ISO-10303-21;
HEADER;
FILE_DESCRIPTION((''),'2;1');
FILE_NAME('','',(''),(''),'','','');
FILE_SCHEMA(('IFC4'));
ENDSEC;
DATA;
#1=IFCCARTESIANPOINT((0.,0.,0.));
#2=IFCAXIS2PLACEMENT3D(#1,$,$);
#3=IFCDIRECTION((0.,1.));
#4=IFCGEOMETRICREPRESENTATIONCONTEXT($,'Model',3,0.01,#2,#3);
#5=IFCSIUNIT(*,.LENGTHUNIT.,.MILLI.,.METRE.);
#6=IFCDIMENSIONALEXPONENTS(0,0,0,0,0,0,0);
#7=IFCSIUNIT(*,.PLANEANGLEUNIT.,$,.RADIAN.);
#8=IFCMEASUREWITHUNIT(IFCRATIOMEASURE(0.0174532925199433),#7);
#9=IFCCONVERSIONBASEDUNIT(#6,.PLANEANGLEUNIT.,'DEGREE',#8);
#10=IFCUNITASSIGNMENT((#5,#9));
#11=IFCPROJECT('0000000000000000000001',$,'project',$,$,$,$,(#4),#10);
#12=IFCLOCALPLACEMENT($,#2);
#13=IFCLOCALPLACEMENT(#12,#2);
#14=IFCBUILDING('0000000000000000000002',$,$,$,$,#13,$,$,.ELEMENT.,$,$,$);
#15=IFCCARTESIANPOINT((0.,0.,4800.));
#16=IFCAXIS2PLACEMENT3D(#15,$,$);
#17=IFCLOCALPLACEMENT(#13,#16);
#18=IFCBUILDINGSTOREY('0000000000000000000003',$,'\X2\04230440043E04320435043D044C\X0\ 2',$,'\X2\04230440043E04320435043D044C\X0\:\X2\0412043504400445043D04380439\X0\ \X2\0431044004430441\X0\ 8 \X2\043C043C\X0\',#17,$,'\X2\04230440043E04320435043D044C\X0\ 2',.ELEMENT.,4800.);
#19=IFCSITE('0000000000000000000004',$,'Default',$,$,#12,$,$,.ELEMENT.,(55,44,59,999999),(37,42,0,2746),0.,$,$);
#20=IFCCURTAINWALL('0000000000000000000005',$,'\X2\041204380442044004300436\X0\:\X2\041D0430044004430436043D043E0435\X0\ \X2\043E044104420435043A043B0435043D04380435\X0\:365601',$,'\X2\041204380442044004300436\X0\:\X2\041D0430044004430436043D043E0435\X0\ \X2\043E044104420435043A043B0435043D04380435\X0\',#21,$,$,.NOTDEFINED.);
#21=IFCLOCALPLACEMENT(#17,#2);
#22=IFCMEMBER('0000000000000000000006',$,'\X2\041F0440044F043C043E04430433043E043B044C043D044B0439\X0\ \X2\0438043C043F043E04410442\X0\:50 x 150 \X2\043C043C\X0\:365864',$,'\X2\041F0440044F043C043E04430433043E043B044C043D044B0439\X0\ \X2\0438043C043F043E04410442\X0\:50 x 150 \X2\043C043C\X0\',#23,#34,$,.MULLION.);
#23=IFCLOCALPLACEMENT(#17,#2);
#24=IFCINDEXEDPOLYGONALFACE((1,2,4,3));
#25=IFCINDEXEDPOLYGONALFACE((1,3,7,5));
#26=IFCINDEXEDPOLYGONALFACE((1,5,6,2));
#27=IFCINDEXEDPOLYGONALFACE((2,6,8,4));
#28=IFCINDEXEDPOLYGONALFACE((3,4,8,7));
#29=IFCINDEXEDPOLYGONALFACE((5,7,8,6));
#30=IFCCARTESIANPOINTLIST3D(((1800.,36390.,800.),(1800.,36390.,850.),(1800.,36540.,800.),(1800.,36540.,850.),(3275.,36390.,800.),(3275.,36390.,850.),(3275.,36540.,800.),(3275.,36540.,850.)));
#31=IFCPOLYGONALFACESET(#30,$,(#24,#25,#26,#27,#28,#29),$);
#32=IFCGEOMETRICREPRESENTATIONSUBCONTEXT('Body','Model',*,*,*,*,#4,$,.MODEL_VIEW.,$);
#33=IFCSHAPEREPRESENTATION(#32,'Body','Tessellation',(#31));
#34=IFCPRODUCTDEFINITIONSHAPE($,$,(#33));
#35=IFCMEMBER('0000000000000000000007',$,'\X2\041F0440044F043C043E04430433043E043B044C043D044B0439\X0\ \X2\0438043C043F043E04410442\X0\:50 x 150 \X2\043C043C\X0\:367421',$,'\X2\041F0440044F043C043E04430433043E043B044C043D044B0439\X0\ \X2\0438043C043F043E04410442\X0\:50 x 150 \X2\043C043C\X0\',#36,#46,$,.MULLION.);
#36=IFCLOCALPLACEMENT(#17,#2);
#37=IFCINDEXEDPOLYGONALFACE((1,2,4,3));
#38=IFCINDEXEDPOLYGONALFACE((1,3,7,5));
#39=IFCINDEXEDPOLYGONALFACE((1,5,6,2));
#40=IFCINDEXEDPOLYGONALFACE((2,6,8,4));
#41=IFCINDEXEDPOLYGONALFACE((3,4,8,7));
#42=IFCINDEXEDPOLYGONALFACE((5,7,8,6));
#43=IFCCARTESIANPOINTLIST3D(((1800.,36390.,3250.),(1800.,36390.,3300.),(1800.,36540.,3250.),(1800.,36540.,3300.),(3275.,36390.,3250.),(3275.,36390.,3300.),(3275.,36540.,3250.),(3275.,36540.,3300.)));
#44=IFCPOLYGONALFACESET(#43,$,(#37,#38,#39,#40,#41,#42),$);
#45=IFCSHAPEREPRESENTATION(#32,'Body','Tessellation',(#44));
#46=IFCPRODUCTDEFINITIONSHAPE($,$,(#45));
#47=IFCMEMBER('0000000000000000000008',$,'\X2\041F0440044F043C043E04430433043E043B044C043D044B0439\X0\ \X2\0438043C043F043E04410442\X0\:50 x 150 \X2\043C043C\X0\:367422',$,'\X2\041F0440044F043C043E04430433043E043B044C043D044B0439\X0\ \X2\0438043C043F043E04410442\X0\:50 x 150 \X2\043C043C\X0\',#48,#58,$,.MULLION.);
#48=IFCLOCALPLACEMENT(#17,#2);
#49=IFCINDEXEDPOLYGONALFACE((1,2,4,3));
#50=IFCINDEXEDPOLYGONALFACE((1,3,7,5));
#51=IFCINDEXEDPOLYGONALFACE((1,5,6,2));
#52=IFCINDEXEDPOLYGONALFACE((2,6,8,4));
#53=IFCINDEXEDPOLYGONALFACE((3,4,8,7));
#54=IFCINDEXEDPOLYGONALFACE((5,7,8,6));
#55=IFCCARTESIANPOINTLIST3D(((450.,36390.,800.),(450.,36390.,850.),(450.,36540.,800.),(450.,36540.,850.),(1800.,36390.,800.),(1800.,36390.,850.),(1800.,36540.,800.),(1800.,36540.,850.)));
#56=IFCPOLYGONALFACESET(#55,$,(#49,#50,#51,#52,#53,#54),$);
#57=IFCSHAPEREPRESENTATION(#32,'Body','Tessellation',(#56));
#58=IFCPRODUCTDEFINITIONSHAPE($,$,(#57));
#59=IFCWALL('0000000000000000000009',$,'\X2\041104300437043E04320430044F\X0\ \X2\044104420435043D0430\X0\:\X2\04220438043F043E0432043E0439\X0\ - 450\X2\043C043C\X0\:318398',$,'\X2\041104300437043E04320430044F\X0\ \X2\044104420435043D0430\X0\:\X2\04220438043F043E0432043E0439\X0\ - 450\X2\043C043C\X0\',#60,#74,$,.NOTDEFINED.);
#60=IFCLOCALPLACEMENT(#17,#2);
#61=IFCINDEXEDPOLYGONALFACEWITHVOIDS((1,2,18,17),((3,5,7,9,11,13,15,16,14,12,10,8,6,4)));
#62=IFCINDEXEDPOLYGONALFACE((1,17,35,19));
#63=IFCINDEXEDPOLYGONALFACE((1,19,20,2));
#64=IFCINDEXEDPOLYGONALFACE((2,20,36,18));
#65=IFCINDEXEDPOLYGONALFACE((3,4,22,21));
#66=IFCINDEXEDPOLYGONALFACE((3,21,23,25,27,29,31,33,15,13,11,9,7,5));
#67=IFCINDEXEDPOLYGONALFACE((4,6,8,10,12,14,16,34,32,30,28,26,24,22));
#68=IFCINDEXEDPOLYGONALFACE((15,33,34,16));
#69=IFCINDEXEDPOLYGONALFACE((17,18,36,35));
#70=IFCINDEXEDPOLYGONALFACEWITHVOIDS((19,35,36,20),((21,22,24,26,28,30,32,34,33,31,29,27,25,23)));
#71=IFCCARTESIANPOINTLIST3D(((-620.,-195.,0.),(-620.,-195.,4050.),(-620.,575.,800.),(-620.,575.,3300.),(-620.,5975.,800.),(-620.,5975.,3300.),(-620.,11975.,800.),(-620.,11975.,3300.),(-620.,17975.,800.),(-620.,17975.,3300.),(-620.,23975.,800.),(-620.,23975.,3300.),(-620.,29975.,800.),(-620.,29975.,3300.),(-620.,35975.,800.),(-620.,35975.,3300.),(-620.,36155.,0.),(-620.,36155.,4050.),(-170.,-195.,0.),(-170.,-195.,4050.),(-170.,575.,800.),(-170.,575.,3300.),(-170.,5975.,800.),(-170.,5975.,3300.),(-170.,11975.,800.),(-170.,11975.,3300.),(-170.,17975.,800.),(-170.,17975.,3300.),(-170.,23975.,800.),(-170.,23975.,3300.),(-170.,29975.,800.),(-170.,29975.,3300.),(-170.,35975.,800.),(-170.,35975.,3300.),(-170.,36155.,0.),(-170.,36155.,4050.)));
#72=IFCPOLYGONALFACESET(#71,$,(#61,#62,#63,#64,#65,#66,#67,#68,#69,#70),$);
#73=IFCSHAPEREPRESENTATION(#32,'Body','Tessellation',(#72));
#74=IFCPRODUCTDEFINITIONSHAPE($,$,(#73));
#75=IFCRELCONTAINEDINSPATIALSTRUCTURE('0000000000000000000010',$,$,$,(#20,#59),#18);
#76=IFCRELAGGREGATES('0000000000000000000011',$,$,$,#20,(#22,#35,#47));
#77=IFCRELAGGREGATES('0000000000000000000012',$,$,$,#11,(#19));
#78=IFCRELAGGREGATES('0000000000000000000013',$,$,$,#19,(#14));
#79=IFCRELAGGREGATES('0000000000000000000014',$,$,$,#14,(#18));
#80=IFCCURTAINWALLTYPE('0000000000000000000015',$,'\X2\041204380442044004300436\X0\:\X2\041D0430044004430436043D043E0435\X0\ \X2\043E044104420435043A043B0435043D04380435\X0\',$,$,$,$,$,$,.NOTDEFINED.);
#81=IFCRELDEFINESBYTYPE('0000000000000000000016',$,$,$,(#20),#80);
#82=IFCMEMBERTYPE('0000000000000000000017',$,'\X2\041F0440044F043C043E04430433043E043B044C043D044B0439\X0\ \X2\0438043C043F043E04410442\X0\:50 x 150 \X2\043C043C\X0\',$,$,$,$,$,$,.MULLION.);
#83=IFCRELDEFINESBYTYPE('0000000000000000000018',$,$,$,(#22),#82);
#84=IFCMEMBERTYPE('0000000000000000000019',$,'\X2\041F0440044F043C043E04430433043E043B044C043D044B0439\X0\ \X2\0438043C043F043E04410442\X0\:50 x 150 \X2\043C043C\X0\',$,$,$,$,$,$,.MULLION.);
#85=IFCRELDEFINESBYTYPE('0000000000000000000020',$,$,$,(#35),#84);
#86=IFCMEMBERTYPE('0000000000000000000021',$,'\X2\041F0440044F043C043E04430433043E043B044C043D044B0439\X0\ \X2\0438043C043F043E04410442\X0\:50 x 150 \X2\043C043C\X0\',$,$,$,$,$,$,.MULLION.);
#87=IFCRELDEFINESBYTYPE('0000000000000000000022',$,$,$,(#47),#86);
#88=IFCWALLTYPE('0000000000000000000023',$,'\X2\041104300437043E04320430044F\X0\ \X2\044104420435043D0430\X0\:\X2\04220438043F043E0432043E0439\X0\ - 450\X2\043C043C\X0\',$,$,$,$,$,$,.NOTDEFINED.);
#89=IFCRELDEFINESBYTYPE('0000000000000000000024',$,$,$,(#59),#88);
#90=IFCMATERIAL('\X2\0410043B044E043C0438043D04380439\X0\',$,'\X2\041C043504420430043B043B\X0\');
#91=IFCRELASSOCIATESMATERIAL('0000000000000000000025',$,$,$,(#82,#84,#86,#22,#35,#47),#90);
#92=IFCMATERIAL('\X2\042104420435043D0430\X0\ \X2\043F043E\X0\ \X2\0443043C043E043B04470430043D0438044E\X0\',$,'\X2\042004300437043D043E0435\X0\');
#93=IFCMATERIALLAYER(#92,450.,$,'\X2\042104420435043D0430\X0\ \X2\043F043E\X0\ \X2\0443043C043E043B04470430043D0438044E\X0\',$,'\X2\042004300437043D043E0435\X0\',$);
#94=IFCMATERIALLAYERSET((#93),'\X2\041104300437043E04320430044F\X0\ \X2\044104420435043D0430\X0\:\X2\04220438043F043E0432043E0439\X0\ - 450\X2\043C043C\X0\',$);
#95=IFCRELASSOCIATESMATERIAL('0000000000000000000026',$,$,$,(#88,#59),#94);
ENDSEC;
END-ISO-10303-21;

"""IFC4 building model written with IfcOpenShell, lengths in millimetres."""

from ifc_helpers import new_model, entity, si_unit, converted_unit, direction, frame, frame_2d, origin, origin_2d_with_axis, place, context, subcontext, project, spatial, rectangle, extrude, source, transform, mapped, material, layer, layer_set, layer_usage, material_profile, profile_set, profile_usage, type_object, type_shapes, element, aggregate, save


model = new_model("IFC4")

# Units and contexts
model_context = context("Model", 3, precision=0.01, world=origin(), true_north=direction((0.0, 1.0)))
body_context = subcontext(model_context, "Body", "Model", "MODEL_VIEW")
ifc_project = project(units=[si_unit("LENGTHUNIT", "METRE", prefix="MILLI"), converted_unit("PLANEANGLEUNIT", "DEGREE", entity("IfcRatioMeasure", 0.0174532925199433), si_unit("PLANEANGLEUNIT", "RADIAN"), dimensions=[0, 0, 0, 0, 0, 0, 0])], contexts=[model_context])

# Site, building, storey
site_placement = place(None, origin())
site = spatial("IfcSite", under=ifc_project, at=site_placement, Name="Default", CompositionType="ELEMENT", RefLatitude=(55, 44, 59, 999999), RefLongitude=(37, 42, 0, 2746), RefElevation=0.0)
building_placement = place(site_placement, origin())
building = spatial("IfcBuilding", under=site, at=building_placement, CompositionType="ELEMENT")
storey_placement = place(building_placement, frame((0.0, 0.0, 4800.0)))
storey = spatial("IfcBuildingStorey", under=building, at=storey_placement, Name="Уровень 2", ObjectType="Уровень:Верхний брус 8 мм", LongName="Уровень 2", CompositionType="ELEMENT", Elevation=4800.0)

# Shared definitions
curtain_wall_type = type_object("IfcCurtainWallType", Name="Витраж:Наружное остекление", PredefinedType="NOTDEFINED")
ifc_material_1 = material(Name="Алюминий", Category="Металл")
ifc_material_profile = material_profile(ifc_material_1, rectangle(XDim=150.0, YDim=50.0, at=origin_2d_with_axis()), Name="50 x 150 мм")
ifc_profile_set = profile_set([ifc_material_profile], Name="50 x 150 мм")

# Curtain wall
curtain_wall_1_placement = place(storey_placement, frame((0.0, 0.0, -4800.0)))
curtain_wall_1 = element("IfcCurtainWall", 1, at=curtain_wall_1_placement, inside=storey, type_object=curtain_wall_type, Name="Витраж:Наружное остекление:365601", ObjectType="Витраж:Наружное остекление", PredefinedType="NOTDEFINED")

# Members
ifc_profile_usage_1 = profile_usage(ifc_profile_set)
member_type_1 = type_object("IfcMemberType", Name="Прямоугольный импост:50 x 150 мм", PredefinedType="MULLION", material=ifc_profile_set)
shared_shape_1 = source(origin(), body_context, "Body", "SweptSolid", [
    extrude(rectangle(XDim=150.0, YDim=50.0, at=origin_2d_with_axis()), frame((-25.0, 0.0, -1475.0), z_axis=(0.0, 0.0, 1.0), x_axis=(0.0, -1.0, 0.0)), (0.0, 0.0, 1.0), 1475.0),
])
type_shapes(member_type_1, [shared_shape_1])
member_1_placement = place(storey_placement, frame((3275.0, 36465.0, 800.0), z_axis=(1.0, 0.0, 0.0), x_axis=(0.0, 0.0, -1.0)))
member_1 = element("IfcMember", 2, at=member_1_placement, type_object=member_type_1, material=ifc_profile_usage_1, Name="Прямоугольный импост:50 x 150 мм:365864", ObjectType="Прямоугольный импост:50 x 150 мм", PredefinedType="MULLION", context=body_context, shape_type="MappedRepresentation", body=[
    mapped(shared_shape_1, transform((0.0, 0.0, 0.0), scale=1.0)),
])
ifc_profile_usage_2 = profile_usage(ifc_profile_set)
member_type_2 = type_object("IfcMemberType", Name="Прямоугольный импост:50 x 150 мм", PredefinedType="MULLION", material=ifc_profile_set)
shared_shape_2 = source(origin(), body_context, "Body", "SweptSolid", [
    extrude(rectangle(XDim=150.0, YDim=50.0, at=origin_2d_with_axis()), frame((-25.0, 0.0, -1475.0), z_axis=(0.0, 0.0, 1.0), x_axis=(0.0, -1.0, 0.0)), (0.0, 0.0, 1.0), 1475.0),
])
type_shapes(member_type_2, [shared_shape_2])
member_2_placement = place(storey_placement, frame((1800.0, 36465.0, 3300.0), z_axis=(-1.0, 0.0, 0.0), x_axis=(0.0, 0.0, 1.0)))
member_2 = element("IfcMember", 3, at=member_2_placement, type_object=member_type_2, material=ifc_profile_usage_2, Name="Прямоугольный импост:50 x 150 мм:367421", ObjectType="Прямоугольный импост:50 x 150 мм", PredefinedType="MULLION", context=body_context, shape_type="MappedRepresentation", body=[
    mapped(shared_shape_2, transform((0.0, 0.0, 0.0), scale=1.0)),
])
ifc_profile_usage_3 = profile_usage(ifc_profile_set)
member_type_3 = type_object("IfcMemberType", Name="Прямоугольный импост:50 x 150 мм", PredefinedType="MULLION", material=ifc_profile_set)
shared_shape_3 = source(origin(), body_context, "Body", "SweptSolid", [
    extrude(rectangle(XDim=150.0, YDim=50.0, at=origin_2d_with_axis()), frame((-25.0, 0.0, -1350.0), z_axis=(0.0, 0.0, 1.0), x_axis=(0.0, -1.0, 0.0)), (0.0, 0.0, 1.0), 1350.0),
])
type_shapes(member_type_3, [shared_shape_3])
member_3_placement = place(storey_placement, frame((1800.0, 36465.0, 800.0), z_axis=(1.0, 0.0, 0.0), x_axis=(0.0, 0.0, -1.0)))
member_3 = element("IfcMember", 4, at=member_3_placement, type_object=member_type_3, material=ifc_profile_usage_3, Name="Прямоугольный импост:50 x 150 мм:367422", ObjectType="Прямоугольный импост:50 x 150 мм", PredefinedType="MULLION", context=body_context, shape_type="MappedRepresentation", body=[
    mapped(shared_shape_3, transform((0.0, 0.0, 0.0), scale=1.0)),
])

aggregate(curtain_wall_1, [member_1, member_2, member_3])

# Wall, openings
ifc_material_2 = material(Name="Стена по умолчанию", Category="Разное")
ifc_layer = layer(ifc_material_2, 450.0, Name="Стена по умолчанию", Category="Разное")
ifc_layer_set = layer_set([ifc_layer], Name="Базовая стена:Типовой - 450мм")
ifc_layer_usage = layer_usage(ifc_layer_set, "AXIS2", "NEGATIVE", 225.0)
wall_type = type_object("IfcWallType", Name="Базовая стена:Типовой - 450мм", PredefinedType="NOTDEFINED", material=ifc_layer_set)
wall_placement = place(storey_placement, frame((-395.0, 36155.0, 0.0), z_axis=(0.0, 0.0, 1.0), x_axis=(0.0, -1.0, 0.0)))
wall = element("IfcWall", 5, at=wall_placement, inside=storey, type_object=wall_type, material=ifc_layer_usage, Name="Базовая стена:Типовой - 450мм:318398", ObjectType="Базовая стена:Типовой - 450мм", PredefinedType="NOTDEFINED", context=body_context, shape_type="SweptSolid", body=[
    extrude(rectangle(XDim=36350.0, YDim=450.0, at=frame_2d((18175.0, 0.0), x_axis=(-1.0, 0.0))), origin(), (0.0, 0.0, 1.0), 4050.0),
])
opening_1_placement = place(wall_placement, frame((35580.0, -377.4, 800.0)))
element("IfcOpeningElement", 6, at=opening_1_placement, cuts=wall, ObjectType="Opening", PredefinedType="OPENING", context=body_context, shape_type="SweptSolid", body=[
    extrude(rectangle(XDim=2500.0, YDim=5400.0, at=frame_2d((0.0, 0.0), x_axis=(0.0, 1.0))), frame((-2700.0, 0.0, 1250.0), z_axis=(0.0, 1.0, 0.0), x_axis=(-1.0, 0.0, 0.0)), (0.0, 0.0, 1.0), 754.8),
])
opening_2_placement = place(wall_placement, frame((30180.0, -377.4, 800.0)))
element("IfcOpeningElement", 7, at=opening_2_placement, cuts=wall, ObjectType="Opening", PredefinedType="OPENING", context=body_context, shape_type="SweptSolid", body=[
    extrude(rectangle(XDim=2500.0, YDim=6000.0, at=frame_2d((0.0, 0.0), x_axis=(0.0, 1.0))), frame((-3000.0, 0.0, 1250.0), z_axis=(0.0, 1.0, 0.0), x_axis=(-1.0, 0.0, 0.0)), (0.0, 0.0, 1.0), 754.8),
])
opening_3_placement = place(wall_placement, frame((24180.0, -377.4, 800.0)))
element("IfcOpeningElement", 8, at=opening_3_placement, cuts=wall, ObjectType="Opening", PredefinedType="OPENING", context=body_context, shape_type="SweptSolid", body=[
    extrude(rectangle(XDim=2500.0, YDim=6000.0, at=frame_2d((0.0, 0.0), x_axis=(0.0, 1.0))), frame((-3000.0, 0.0, 1250.0), z_axis=(0.0, 1.0, 0.0), x_axis=(-1.0, 0.0, 0.0)), (0.0, 0.0, 1.0), 754.8),
])
opening_4_placement = place(wall_placement, frame((18180.0, -377.4, 800.0)))
element("IfcOpeningElement", 9, at=opening_4_placement, cuts=wall, ObjectType="Opening", PredefinedType="OPENING", context=body_context, shape_type="SweptSolid", body=[
    extrude(rectangle(XDim=2500.0, YDim=6000.0, at=frame_2d((0.0, 0.0), x_axis=(0.0, 1.0))), frame((-3000.0, 0.0, 1250.0), z_axis=(0.0, 1.0, 0.0), x_axis=(-1.0, 0.0, 0.0)), (0.0, 0.0, 1.0), 754.8),
])
opening_5_placement = place(wall_placement, frame((12180.0, -377.4, 800.0)))
element("IfcOpeningElement", 10, at=opening_5_placement, cuts=wall, ObjectType="Opening", PredefinedType="OPENING", context=body_context, shape_type="SweptSolid", body=[
    extrude(rectangle(XDim=2500.0, YDim=6000.0, at=frame_2d((0.0, 0.0), x_axis=(0.0, 1.0))), frame((-3000.0, 0.0, 1250.0), z_axis=(0.0, 1.0, 0.0), x_axis=(-1.0, 0.0, 0.0)), (0.0, 0.0, 1.0), 754.8),
])
opening_6_placement = place(wall_placement, frame((6180.0, -377.4, 800.0)))
element("IfcOpeningElement", 11, at=opening_6_placement, cuts=wall, ObjectType="Opening", PredefinedType="OPENING", context=body_context, shape_type="SweptSolid", body=[
    extrude(rectangle(XDim=2500.0, YDim=6000.0, at=frame_2d((0.0, 0.0), x_axis=(0.0, 1.0))), frame((-3000.0, 0.0, 1250.0), z_axis=(0.0, 1.0, 0.0), x_axis=(-1.0, 0.0, 0.0)), (0.0, 0.0, 1.0), 754.8),
])

save(model, "model.ifc")
